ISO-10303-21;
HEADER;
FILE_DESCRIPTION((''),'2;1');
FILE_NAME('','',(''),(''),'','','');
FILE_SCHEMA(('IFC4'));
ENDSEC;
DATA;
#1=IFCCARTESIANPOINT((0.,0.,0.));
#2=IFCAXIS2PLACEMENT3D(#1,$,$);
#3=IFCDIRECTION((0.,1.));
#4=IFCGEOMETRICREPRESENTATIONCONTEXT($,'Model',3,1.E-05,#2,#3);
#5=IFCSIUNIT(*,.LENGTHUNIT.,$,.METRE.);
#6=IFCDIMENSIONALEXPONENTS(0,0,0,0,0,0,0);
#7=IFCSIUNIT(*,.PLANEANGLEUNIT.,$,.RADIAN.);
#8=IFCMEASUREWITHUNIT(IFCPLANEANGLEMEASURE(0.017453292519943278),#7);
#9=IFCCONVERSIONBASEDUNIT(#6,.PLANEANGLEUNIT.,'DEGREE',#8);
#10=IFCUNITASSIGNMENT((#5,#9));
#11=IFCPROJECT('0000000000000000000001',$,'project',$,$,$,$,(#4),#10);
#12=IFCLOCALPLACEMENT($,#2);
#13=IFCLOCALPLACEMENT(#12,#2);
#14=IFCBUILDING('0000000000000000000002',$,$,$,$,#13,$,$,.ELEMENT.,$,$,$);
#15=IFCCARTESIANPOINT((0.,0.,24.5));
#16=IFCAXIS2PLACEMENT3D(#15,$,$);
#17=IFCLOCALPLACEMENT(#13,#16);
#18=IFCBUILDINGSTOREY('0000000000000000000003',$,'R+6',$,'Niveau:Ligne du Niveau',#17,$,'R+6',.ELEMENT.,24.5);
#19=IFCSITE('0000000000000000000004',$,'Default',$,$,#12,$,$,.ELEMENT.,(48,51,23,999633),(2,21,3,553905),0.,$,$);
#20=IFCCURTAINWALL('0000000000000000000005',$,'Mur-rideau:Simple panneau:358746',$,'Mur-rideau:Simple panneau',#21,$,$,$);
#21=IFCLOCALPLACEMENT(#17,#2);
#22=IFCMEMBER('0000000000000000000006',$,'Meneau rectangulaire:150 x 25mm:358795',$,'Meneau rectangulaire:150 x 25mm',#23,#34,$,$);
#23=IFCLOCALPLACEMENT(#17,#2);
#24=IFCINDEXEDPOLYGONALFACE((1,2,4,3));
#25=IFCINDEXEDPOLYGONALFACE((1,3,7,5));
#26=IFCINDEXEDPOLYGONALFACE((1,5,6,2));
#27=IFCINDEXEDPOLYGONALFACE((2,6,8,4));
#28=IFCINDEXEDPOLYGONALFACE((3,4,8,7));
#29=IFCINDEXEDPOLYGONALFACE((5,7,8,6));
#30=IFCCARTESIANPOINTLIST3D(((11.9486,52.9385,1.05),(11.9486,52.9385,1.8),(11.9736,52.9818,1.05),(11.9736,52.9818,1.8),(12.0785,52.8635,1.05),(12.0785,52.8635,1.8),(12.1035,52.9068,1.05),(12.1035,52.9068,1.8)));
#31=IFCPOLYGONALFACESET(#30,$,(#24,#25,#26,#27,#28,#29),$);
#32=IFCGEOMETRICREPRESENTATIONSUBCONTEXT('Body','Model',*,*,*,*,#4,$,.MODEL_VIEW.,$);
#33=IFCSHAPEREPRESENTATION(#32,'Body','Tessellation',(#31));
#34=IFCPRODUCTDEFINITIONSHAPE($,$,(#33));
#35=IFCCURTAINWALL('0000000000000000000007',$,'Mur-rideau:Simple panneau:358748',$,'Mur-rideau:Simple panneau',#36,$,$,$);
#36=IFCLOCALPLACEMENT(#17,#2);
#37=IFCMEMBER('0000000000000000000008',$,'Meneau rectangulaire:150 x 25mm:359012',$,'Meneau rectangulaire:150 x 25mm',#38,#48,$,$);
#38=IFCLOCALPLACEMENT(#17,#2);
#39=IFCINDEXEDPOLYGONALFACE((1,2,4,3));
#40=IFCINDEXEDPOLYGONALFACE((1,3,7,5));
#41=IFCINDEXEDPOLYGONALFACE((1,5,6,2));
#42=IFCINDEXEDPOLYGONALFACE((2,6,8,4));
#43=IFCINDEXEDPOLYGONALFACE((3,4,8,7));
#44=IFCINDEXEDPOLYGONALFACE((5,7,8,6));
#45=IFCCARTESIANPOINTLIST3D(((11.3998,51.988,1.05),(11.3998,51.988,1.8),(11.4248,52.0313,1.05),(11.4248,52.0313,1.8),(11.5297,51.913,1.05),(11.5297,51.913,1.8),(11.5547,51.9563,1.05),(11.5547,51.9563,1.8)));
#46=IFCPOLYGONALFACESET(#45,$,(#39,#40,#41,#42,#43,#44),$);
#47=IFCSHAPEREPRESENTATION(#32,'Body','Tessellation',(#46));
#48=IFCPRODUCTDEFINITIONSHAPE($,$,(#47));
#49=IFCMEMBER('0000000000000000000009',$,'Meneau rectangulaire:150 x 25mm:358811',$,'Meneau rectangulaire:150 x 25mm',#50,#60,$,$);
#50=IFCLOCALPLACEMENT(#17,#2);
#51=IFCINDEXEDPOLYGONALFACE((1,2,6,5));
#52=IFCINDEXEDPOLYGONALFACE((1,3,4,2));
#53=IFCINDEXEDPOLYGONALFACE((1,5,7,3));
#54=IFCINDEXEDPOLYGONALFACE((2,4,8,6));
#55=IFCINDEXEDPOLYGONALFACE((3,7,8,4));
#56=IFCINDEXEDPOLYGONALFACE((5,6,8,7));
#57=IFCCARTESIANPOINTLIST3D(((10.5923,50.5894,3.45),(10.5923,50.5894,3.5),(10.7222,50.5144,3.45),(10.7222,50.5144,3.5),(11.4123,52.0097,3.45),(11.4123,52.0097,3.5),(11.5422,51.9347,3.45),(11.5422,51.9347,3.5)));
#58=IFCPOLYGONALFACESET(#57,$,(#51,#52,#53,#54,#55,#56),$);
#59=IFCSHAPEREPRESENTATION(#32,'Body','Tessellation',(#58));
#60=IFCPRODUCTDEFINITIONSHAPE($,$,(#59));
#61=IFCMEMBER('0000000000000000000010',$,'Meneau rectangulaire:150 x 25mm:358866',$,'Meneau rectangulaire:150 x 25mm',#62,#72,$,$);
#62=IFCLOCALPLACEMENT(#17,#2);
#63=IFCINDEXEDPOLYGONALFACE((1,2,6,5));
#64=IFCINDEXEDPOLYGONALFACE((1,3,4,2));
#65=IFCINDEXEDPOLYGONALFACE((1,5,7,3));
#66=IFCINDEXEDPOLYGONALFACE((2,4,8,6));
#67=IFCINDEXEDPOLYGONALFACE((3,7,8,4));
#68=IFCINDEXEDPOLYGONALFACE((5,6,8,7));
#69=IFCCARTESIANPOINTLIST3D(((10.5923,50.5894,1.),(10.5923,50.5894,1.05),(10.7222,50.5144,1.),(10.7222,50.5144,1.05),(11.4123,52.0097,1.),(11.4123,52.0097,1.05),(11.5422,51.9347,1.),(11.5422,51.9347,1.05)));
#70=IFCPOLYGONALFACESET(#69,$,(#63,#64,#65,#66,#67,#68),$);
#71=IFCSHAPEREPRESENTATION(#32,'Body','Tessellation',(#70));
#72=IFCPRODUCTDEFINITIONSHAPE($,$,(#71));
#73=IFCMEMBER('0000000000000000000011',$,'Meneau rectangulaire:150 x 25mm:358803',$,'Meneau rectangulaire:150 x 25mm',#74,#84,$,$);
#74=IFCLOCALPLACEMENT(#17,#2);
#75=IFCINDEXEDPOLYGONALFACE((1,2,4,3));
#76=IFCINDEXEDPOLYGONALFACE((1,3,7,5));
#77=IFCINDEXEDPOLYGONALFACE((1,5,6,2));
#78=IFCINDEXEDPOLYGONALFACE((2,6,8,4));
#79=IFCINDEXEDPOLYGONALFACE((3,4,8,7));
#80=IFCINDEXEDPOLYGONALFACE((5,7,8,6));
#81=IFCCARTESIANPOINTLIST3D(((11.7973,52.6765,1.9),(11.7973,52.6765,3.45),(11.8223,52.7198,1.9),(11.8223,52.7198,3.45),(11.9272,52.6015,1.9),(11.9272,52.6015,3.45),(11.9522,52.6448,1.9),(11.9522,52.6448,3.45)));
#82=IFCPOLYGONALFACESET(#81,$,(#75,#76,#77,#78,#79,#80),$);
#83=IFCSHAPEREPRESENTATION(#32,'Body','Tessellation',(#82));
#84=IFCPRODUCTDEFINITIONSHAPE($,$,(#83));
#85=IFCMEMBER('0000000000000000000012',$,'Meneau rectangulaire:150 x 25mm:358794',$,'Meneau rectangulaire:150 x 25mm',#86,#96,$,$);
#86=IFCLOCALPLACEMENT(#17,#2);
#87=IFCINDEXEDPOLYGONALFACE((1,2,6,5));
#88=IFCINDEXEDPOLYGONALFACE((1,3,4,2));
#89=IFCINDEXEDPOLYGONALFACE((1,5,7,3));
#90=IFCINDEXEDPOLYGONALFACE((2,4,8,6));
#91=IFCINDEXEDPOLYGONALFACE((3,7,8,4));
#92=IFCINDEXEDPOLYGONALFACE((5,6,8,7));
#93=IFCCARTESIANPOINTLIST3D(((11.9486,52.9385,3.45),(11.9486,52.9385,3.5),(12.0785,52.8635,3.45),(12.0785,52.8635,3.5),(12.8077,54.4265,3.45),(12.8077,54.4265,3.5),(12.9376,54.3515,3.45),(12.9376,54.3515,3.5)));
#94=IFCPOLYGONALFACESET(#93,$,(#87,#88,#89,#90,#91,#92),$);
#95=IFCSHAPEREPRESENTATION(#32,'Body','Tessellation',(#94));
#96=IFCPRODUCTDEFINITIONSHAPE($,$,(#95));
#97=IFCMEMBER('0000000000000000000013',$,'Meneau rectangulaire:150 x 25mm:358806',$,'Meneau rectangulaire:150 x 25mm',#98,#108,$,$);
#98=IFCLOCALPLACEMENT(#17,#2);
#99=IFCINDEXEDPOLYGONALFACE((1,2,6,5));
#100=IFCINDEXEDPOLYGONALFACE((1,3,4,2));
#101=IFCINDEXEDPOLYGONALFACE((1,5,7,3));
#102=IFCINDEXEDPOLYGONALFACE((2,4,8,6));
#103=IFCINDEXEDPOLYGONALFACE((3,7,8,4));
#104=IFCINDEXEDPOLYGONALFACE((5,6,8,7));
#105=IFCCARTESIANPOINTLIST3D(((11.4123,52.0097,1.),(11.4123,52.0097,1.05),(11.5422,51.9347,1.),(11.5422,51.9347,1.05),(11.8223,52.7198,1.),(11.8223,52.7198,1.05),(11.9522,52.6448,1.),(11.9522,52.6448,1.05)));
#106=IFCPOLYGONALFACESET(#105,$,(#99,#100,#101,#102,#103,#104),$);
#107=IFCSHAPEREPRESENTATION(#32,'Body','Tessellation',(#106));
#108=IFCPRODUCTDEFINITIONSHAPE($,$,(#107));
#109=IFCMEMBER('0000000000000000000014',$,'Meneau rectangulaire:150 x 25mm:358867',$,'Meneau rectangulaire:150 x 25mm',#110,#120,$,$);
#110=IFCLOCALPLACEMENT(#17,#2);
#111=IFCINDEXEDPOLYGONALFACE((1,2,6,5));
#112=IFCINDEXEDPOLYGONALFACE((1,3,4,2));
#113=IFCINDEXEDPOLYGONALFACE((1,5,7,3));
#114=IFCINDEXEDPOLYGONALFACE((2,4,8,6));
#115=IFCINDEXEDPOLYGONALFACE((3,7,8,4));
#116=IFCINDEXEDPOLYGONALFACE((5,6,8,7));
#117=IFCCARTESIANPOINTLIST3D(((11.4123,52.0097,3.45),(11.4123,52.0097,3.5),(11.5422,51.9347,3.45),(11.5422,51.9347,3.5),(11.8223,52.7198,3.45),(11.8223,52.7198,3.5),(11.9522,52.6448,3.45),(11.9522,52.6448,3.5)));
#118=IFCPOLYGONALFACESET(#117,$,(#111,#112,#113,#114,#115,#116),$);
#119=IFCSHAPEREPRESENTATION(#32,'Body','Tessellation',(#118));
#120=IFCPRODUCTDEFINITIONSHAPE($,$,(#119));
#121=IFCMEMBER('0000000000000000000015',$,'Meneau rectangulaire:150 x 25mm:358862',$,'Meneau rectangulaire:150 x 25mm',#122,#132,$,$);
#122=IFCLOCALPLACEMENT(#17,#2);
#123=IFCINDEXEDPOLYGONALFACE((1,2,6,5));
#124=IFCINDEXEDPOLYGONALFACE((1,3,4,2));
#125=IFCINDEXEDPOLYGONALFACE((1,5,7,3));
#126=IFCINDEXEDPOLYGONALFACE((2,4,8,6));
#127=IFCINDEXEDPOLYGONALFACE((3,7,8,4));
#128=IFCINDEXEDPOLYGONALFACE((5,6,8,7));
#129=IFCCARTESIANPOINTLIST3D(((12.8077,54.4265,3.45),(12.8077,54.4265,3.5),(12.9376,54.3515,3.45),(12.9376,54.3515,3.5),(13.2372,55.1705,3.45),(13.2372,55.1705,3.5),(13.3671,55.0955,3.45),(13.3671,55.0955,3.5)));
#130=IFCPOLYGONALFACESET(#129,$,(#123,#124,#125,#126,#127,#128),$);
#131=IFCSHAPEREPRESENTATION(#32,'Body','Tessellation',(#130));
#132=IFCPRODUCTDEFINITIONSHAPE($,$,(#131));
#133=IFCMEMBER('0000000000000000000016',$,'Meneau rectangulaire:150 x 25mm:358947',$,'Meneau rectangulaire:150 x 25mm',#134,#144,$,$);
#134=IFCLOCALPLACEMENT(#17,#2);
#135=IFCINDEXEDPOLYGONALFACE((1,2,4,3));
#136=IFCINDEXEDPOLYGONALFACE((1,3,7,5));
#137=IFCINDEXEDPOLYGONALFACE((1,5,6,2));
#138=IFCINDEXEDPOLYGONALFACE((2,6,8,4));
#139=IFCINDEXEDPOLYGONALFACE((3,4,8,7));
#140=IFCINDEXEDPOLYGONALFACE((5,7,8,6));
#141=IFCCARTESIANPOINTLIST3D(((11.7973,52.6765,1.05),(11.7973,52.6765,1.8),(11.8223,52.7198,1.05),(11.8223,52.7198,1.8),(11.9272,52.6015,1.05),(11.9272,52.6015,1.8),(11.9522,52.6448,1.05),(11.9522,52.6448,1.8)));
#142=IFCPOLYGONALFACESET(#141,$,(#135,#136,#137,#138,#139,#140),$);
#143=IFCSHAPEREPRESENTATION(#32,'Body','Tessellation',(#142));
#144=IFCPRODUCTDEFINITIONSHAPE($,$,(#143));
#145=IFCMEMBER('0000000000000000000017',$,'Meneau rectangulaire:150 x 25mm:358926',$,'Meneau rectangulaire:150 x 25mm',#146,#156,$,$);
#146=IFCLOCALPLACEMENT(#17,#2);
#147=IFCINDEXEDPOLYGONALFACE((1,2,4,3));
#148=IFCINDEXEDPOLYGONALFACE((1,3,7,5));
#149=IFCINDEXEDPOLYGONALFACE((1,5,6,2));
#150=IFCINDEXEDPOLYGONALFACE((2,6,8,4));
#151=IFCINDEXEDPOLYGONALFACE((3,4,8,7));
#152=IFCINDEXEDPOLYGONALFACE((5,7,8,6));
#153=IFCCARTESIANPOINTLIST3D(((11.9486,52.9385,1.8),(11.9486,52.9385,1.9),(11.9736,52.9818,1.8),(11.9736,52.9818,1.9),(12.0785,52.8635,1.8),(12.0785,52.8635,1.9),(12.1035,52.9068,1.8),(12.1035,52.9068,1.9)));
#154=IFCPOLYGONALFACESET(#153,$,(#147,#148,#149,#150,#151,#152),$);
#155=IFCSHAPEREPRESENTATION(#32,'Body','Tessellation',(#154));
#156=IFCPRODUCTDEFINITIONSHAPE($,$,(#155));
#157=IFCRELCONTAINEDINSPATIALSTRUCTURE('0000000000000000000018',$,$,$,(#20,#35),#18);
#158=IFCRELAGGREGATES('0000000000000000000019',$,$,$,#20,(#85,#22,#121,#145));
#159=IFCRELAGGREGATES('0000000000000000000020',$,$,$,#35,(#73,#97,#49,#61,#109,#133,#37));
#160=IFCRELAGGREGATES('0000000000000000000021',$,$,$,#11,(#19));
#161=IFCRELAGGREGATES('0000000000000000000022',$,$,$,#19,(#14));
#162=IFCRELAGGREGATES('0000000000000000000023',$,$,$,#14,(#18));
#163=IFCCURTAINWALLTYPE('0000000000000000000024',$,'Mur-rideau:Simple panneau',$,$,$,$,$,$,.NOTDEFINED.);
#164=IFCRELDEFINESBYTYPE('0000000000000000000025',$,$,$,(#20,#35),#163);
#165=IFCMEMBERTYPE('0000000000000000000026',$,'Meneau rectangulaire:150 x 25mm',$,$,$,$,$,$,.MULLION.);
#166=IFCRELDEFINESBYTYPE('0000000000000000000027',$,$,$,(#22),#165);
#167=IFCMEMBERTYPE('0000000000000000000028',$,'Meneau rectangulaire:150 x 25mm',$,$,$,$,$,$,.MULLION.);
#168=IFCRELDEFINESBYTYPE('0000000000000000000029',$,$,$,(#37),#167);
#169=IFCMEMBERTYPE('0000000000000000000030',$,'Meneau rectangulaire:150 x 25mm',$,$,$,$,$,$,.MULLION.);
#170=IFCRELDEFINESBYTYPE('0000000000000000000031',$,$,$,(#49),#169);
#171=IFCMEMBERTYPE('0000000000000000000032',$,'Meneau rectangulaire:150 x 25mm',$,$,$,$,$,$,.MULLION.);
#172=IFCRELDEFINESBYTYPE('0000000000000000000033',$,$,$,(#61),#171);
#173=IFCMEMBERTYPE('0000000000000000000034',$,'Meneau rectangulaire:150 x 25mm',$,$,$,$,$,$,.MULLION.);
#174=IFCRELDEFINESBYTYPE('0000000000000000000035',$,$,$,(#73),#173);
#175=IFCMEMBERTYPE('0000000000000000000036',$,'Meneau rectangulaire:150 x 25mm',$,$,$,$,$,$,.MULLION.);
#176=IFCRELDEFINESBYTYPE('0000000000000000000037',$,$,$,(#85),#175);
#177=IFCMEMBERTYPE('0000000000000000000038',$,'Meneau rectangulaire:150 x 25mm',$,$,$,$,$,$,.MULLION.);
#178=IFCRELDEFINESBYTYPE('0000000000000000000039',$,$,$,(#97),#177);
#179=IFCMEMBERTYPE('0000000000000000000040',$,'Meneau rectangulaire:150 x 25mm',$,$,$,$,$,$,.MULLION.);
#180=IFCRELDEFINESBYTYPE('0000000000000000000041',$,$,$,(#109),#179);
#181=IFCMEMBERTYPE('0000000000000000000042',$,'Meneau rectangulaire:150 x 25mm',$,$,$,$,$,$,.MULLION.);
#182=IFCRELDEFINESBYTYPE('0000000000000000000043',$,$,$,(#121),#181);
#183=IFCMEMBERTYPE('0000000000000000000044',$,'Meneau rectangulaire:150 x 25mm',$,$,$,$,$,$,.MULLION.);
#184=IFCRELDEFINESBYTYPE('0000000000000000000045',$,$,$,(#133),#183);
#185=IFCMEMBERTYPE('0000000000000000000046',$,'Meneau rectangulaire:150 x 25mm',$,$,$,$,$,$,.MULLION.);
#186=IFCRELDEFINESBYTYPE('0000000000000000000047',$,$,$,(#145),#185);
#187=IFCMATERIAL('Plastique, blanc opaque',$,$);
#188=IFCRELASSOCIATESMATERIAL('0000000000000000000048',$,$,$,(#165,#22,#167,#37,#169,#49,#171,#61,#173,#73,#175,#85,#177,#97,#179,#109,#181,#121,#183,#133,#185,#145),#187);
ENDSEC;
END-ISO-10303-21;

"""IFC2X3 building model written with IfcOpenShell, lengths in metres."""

from ifc_helpers import new_model, entity, si_unit, converted_unit, direction, frame, frame_2d, origin, origin_2d_with_axis, place, context, subcontext, project, spatial, rectangle, extrude, source, transform, mapped, material, type_object, type_shapes, element, aggregate, save


model = new_model("IFC2X3")

# Units and contexts
model_context = context("Model", 3, precision=1e-05, world=origin(), true_north=direction((0.0, 1.0)))
body_context = subcontext(model_context, "Body", "Model", "MODEL_VIEW")
ifc_project = project(units=[si_unit("LENGTHUNIT", "METRE"), converted_unit("PLANEANGLEUNIT", "DEGREE", entity("IfcPlaneAngleMeasure", 0.017453292519943278), si_unit("PLANEANGLEUNIT", "RADIAN"), dimensions=[0, 0, 0, 0, 0, 0, 0])], contexts=[model_context])

# Site, building, storey
site_placement = place(None, origin())
site = spatial("IfcSite", under=ifc_project, at=site_placement, Name="Default", CompositionType="ELEMENT", RefLatitude=(48, 51, 23, 999633), RefLongitude=(2, 21, 3, 553905), RefElevation=0.0)
building_placement = place(site_placement, origin())
building = spatial("IfcBuilding", under=site, at=building_placement, CompositionType="ELEMENT")
storey_placement = place(building_placement, frame((0.0, 0.0, 24.5)))
storey = spatial("IfcBuildingStorey", under=building, at=storey_placement, Name="R+6", ObjectType="Niveau:Ligne du Niveau", LongName="R+6", CompositionType="ELEMENT", Elevation=24.5)

# Curtain wall, member
curtain_wall_type = type_object("IfcCurtainWallType", Name="Mur-rideau:Simple panneau", PredefinedType="NOTDEFINED")
curtain_wall_1_placement = place(storey_placement, frame((0.0, 0.0, -24.5)))
curtain_wall_1 = element("IfcCurtainWall", 1, at=curtain_wall_1_placement, inside=storey, type_object=curtain_wall_type, Name="Mur-rideau:Simple panneau:358746", ObjectType="Mur-rideau:Simple panneau")
ifc_material_1 = material(Name="Plastique, blanc opaque")
member_type_1 = type_object("IfcMemberType", Name="Meneau rectangulaire:150 x 25mm", PredefinedType="MULLION", material=ifc_material_1)
shared_shape_1 = source(origin(), body_context, "Body", "SweptSolid", [
    extrude(rectangle(XDim=0.05, YDim=0.15, at=origin_2d_with_axis()), frame((-0.025, 0.0, -0.75), z_axis=(0.0, 0.0, 1.0), x_axis=(-1.0, 0.0, 0.0)), (0.0, 0.0, 1.0), 0.75),
])
type_shapes(member_type_1, [shared_shape_1])
member_1_placement = place(curtain_wall_1_placement, frame((12.0135, 52.901, 25.55), z_axis=(0.0, 0.0, -1.0), x_axis=(-0.5, -0.866025, 0.0)))
member_1 = element("IfcMember", 2, at=member_1_placement, type_object=member_type_1, material=ifc_material_1, Name="Meneau rectangulaire:150 x 25mm:358795", ObjectType="Meneau rectangulaire:150 x 25mm", context=body_context, shape_type="MappedRepresentation", body=[
    mapped(shared_shape_1, transform((0.0, 0.0, 0.0), scale=1.0)),
])

# Curtain wall, members
curtain_wall_2_placement = place(storey_placement, frame((0.0, 0.0, -24.5)))
curtain_wall_2 = element("IfcCurtainWall", 3, at=curtain_wall_2_placement, inside=storey, type_object=curtain_wall_type, Name="Mur-rideau:Simple panneau:358748", ObjectType="Mur-rideau:Simple panneau")
member_type_2 = type_object("IfcMemberType", Name="Meneau rectangulaire:150 x 25mm", PredefinedType="MULLION", material=ifc_material_1)
shared_shape_2 = source(origin(), body_context, "Body", "SweptSolid", [
    extrude(rectangle(XDim=0.05, YDim=0.15, at=origin_2d_with_axis()), frame((0.0, 0.0, -0.75), z_axis=(0.0, 0.0, 1.0), x_axis=(-1.0, 0.0, 0.0)), (0.0, 0.0, 1.0), 0.75),
])
type_shapes(member_type_2, [shared_shape_2])
member_2_placement = place(curtain_wall_2_placement, frame((11.4773, 51.9722, 25.55), z_axis=(0.0, 0.0, -1.0), x_axis=(-0.5, -0.866025, 0.0)))
member_2 = element("IfcMember", 4, at=member_2_placement, type_object=member_type_2, material=ifc_material_1, Name="Meneau rectangulaire:150 x 25mm:359012", ObjectType="Meneau rectangulaire:150 x 25mm", context=body_context, shape_type="MappedRepresentation", body=[
    mapped(shared_shape_2, transform((0.0, 0.0, 0.0), scale=1.0)),
])
member_type_3 = type_object("IfcMemberType", Name="Meneau rectangulaire:150 x 25mm", PredefinedType="MULLION", material=ifc_material_1)
shared_shape_3 = source(origin(), body_context, "Body", "SweptSolid", [
    extrude(rectangle(XDim=0.05, YDim=0.15, at=origin_2d_with_axis()), frame((-0.025, 0.0, -1.64), z_axis=(0.0, 0.0, 1.0), x_axis=(-1.0, 0.0, 0.0)), (0.0, 0.0, 1.0), 1.64),
])
type_shapes(member_type_3, [shared_shape_3])
member_3_placement = place(curtain_wall_2_placement, frame((10.6573, 50.5519, 28.0), z_axis=(-0.5, -0.866025, 0.0), x_axis=(0.0, 0.0, 1.0)))
member_3 = element("IfcMember", 5, at=member_3_placement, type_object=member_type_3, material=ifc_material_1, Name="Meneau rectangulaire:150 x 25mm:358811", ObjectType="Meneau rectangulaire:150 x 25mm", context=body_context, shape_type="MappedRepresentation", body=[
    mapped(shared_shape_3, transform((0.0, 0.0, 0.0), scale=1.0)),
])
member_type_4 = type_object("IfcMemberType", Name="Meneau rectangulaire:150 x 25mm", PredefinedType="MULLION", material=ifc_material_1)
shared_shape_4 = source(origin(), body_context, "Body", "SweptSolid", [
    extrude(rectangle(XDim=0.05, YDim=0.15, at=origin_2d_with_axis()), frame((-0.025, 0.0, -1.64), z_axis=(0.0, 0.0, 1.0), x_axis=(-1.0, 0.0, 0.0)), (0.0, 0.0, 1.0), 1.64),
])
type_shapes(member_type_4, [shared_shape_4])
member_4_placement = place(curtain_wall_2_placement, frame((11.4773, 51.9722, 25.5), z_axis=(0.5, 0.866025, 0.0), x_axis=(0.0, 0.0, -1.0)))
member_4 = element("IfcMember", 6, at=member_4_placement, type_object=member_type_4, material=ifc_material_1, Name="Meneau rectangulaire:150 x 25mm:358866", ObjectType="Meneau rectangulaire:150 x 25mm", context=body_context, shape_type="MappedRepresentation", body=[
    mapped(shared_shape_4, transform((0.0, 0.0, 0.0), scale=1.0)),
])
member_type_5 = type_object("IfcMemberType", Name="Meneau rectangulaire:150 x 25mm", PredefinedType="MULLION", material=ifc_material_1)
shared_shape_5 = source(origin(), body_context, "Body", "SweptSolid", [
    extrude(rectangle(XDim=0.05, YDim=0.15, at=origin_2d_with_axis()), frame((-0.025, 0.0, -1.55), z_axis=(0.0, 0.0, 1.0), x_axis=(-1.0, 0.0, 0.0)), (0.0, 0.0, 1.0), 1.55),
])
type_shapes(member_type_5, [shared_shape_5])
member_5_placement = place(curtain_wall_2_placement, frame((11.8873, 52.6823, 27.95), z_axis=(0.0, 0.0, 1.0), x_axis=(0.5, 0.866025, 0.0)))
member_5 = element("IfcMember", 7, at=member_5_placement, type_object=member_type_5, material=ifc_material_1, Name="Meneau rectangulaire:150 x 25mm:358803", ObjectType="Meneau rectangulaire:150 x 25mm", context=body_context, shape_type="MappedRepresentation", body=[
    mapped(shared_shape_5, transform((0.0, 0.0, 0.0), scale=1.0)),
])

# Members
member_type_6 = type_object("IfcMemberType", Name="Meneau rectangulaire:150 x 25mm", PredefinedType="MULLION", material=ifc_material_1)
shared_shape_6 = source(origin(), body_context, "Body", "SweptSolid", [
    extrude(rectangle(XDim=0.05, YDim=0.15, at=origin_2d_with_axis()), frame((-0.025, 0.0, -1.7182), z_axis=(0.0, 0.0, 1.0), x_axis=(-1.0, 0.0, 0.0)), (0.0, 0.0, 1.0), 1.7182),
])
type_shapes(member_type_6, [shared_shape_6])
member_6_placement = place(curtain_wall_1_placement, frame((12.0135, 52.901, 28.0), z_axis=(-0.5, -0.866025, 0.0), x_axis=(0.0, 0.0, 1.0)))
member_6 = element("IfcMember", 8, at=member_6_placement, type_object=member_type_6, material=ifc_material_1, Name="Meneau rectangulaire:150 x 25mm:358794", ObjectType="Meneau rectangulaire:150 x 25mm", context=body_context, shape_type="MappedRepresentation", body=[
    mapped(shared_shape_6, transform((0.0, 0.0, 0.0), scale=1.0)),
])
member_type_7 = type_object("IfcMemberType", Name="Meneau rectangulaire:150 x 25mm", PredefinedType="MULLION", material=ifc_material_1)
shared_shape_7 = source(origin(), body_context, "Body", "SweptSolid", [
    extrude(rectangle(XDim=0.05, YDim=0.15, at=origin_2d_with_axis()), frame((-0.025, 0.0, -0.82), z_axis=(0.0, 0.0, 1.0), x_axis=(-1.0, 0.0, 0.0)), (0.0, 0.0, 1.0), 0.82),
])
type_shapes(member_type_7, [shared_shape_7])
member_7_placement = place(curtain_wall_2_placement, frame((11.8873, 52.6823, 25.5), z_axis=(0.5, 0.866025, 0.0), x_axis=(0.0, 0.0, -1.0)))
member_7 = element("IfcMember", 9, at=member_7_placement, type_object=member_type_7, material=ifc_material_1, Name="Meneau rectangulaire:150 x 25mm:358806", ObjectType="Meneau rectangulaire:150 x 25mm", context=body_context, shape_type="MappedRepresentation", body=[
    mapped(shared_shape_7, transform((0.0, 0.0, 0.0), scale=1.0)),
])
member_type_8 = type_object("IfcMemberType", Name="Meneau rectangulaire:150 x 25mm", PredefinedType="MULLION", material=ifc_material_1)
shared_shape_8 = source(origin(), body_context, "Body", "SweptSolid", [
    extrude(rectangle(XDim=0.05, YDim=0.15, at=frame_2d((0.0, 0.0), x_axis=(1.0, 0.0))), frame((-0.025, 0.0, -0.82), z_axis=(0.0, 0.0, 1.0), x_axis=(-1.0, 0.0, 0.0)), (0.0, 0.0, 1.0), 0.82),
])
type_shapes(member_type_8, [shared_shape_8])
member_8_placement = place(curtain_wall_2_placement, frame((11.4773, 51.9722, 28.0), z_axis=(-0.5, -0.866025, 0.0), x_axis=(0.0, 0.0, 1.0)))
member_8 = element("IfcMember", 10, at=member_8_placement, type_object=member_type_8, material=ifc_material_1, Name="Meneau rectangulaire:150 x 25mm:358867", ObjectType="Meneau rectangulaire:150 x 25mm", context=body_context, shape_type="MappedRepresentation", body=[
    mapped(shared_shape_8, transform((0.0, 0.0, 0.0), scale=1.0)),
])
member_type_9 = type_object("IfcMemberType", Name="Meneau rectangulaire:150 x 25mm", PredefinedType="MULLION", material=ifc_material_1)
shared_shape_9 = source(origin(), body_context, "Body", "SweptSolid", [
    extrude(rectangle(XDim=0.05, YDim=0.15, at=origin_2d_with_axis()), frame((-0.025, 0.0, -0.8591), z_axis=(0.0, 0.0, 1.0), x_axis=(-1.0, 0.0, 0.0)), (0.0, 0.0, 1.0), 0.8591),
])
type_shapes(member_type_9, [shared_shape_9])
member_9_placement = place(curtain_wall_1_placement, frame((12.8726, 54.389, 28.0), z_axis=(-0.5, -0.866025, 0.0), x_axis=(0.0, 0.0, 1.0)))
member_9 = element("IfcMember", 11, at=member_9_placement, type_object=member_type_9, material=ifc_material_1, Name="Meneau rectangulaire:150 x 25mm:358862", ObjectType="Meneau rectangulaire:150 x 25mm", context=body_context, shape_type="MappedRepresentation", body=[
    mapped(shared_shape_9, transform((0.0, 0.0, 0.0), scale=1.0)),
])
member_type_10 = type_object("IfcMemberType", Name="Meneau rectangulaire:150 x 25mm", PredefinedType="MULLION", material=ifc_material_1)
shared_shape_10 = source(origin(), body_context, "Body", "SweptSolid", [
    extrude(rectangle(XDim=0.05, YDim=0.15, at=origin_2d_with_axis()), frame((-0.025, 0.0, -0.75), z_axis=(0.0, 0.0, 1.0), x_axis=(-1.0, 0.0, 0.0)), (0.0, 0.0, 1.0), 0.75),
])
type_shapes(member_type_10, [shared_shape_10])
member_10_placement = place(curtain_wall_2_placement, frame((11.8873, 52.6823, 26.3), z_axis=(0.0, 0.0, 1.0), x_axis=(0.5, 0.866025, 0.0)))
member_10 = element("IfcMember", 12, at=member_10_placement, type_object=member_type_10, material=ifc_material_1, Name="Meneau rectangulaire:150 x 25mm:358947", ObjectType="Meneau rectangulaire:150 x 25mm", context=body_context, shape_type="MappedRepresentation", body=[
    mapped(shared_shape_10, transform((0.0, 0.0, 0.0), scale=1.0)),
])
member_type_11 = type_object("IfcMemberType", Name="Meneau rectangulaire:150 x 25mm", PredefinedType="MULLION", material=ifc_material_1)
shared_shape_11 = source(origin(), body_context, "Body", "SweptSolid", [
    extrude(rectangle(XDim=0.05, YDim=0.15, at=origin_2d_with_axis()), frame((-0.025, 0.0, -0.1), z_axis=(0.0, 0.0, 1.0), x_axis=(-1.0, 0.0, 0.0)), (0.0, 0.0, 1.0), 0.1),
])
type_shapes(member_type_11, [shared_shape_11])
member_11_placement = place(curtain_wall_1_placement, frame((12.0135, 52.901, 26.3), z_axis=(0.0, 0.0, -1.0), x_axis=(-0.5, -0.866025, 0.0)))
member_11 = element("IfcMember", 13, at=member_11_placement, type_object=member_type_11, material=ifc_material_1, Name="Meneau rectangulaire:150 x 25mm:358926", ObjectType="Meneau rectangulaire:150 x 25mm", context=body_context, shape_type="MappedRepresentation", body=[
    mapped(shared_shape_11, transform((0.0, 0.0, 0.0), scale=1.0)),
])

aggregate(curtain_wall_1, [member_6, member_1, member_9, member_11])
aggregate(curtain_wall_2, [member_5, member_7, member_3, member_4, member_8, member_10, member_2])

save(model, "model.ifc")
